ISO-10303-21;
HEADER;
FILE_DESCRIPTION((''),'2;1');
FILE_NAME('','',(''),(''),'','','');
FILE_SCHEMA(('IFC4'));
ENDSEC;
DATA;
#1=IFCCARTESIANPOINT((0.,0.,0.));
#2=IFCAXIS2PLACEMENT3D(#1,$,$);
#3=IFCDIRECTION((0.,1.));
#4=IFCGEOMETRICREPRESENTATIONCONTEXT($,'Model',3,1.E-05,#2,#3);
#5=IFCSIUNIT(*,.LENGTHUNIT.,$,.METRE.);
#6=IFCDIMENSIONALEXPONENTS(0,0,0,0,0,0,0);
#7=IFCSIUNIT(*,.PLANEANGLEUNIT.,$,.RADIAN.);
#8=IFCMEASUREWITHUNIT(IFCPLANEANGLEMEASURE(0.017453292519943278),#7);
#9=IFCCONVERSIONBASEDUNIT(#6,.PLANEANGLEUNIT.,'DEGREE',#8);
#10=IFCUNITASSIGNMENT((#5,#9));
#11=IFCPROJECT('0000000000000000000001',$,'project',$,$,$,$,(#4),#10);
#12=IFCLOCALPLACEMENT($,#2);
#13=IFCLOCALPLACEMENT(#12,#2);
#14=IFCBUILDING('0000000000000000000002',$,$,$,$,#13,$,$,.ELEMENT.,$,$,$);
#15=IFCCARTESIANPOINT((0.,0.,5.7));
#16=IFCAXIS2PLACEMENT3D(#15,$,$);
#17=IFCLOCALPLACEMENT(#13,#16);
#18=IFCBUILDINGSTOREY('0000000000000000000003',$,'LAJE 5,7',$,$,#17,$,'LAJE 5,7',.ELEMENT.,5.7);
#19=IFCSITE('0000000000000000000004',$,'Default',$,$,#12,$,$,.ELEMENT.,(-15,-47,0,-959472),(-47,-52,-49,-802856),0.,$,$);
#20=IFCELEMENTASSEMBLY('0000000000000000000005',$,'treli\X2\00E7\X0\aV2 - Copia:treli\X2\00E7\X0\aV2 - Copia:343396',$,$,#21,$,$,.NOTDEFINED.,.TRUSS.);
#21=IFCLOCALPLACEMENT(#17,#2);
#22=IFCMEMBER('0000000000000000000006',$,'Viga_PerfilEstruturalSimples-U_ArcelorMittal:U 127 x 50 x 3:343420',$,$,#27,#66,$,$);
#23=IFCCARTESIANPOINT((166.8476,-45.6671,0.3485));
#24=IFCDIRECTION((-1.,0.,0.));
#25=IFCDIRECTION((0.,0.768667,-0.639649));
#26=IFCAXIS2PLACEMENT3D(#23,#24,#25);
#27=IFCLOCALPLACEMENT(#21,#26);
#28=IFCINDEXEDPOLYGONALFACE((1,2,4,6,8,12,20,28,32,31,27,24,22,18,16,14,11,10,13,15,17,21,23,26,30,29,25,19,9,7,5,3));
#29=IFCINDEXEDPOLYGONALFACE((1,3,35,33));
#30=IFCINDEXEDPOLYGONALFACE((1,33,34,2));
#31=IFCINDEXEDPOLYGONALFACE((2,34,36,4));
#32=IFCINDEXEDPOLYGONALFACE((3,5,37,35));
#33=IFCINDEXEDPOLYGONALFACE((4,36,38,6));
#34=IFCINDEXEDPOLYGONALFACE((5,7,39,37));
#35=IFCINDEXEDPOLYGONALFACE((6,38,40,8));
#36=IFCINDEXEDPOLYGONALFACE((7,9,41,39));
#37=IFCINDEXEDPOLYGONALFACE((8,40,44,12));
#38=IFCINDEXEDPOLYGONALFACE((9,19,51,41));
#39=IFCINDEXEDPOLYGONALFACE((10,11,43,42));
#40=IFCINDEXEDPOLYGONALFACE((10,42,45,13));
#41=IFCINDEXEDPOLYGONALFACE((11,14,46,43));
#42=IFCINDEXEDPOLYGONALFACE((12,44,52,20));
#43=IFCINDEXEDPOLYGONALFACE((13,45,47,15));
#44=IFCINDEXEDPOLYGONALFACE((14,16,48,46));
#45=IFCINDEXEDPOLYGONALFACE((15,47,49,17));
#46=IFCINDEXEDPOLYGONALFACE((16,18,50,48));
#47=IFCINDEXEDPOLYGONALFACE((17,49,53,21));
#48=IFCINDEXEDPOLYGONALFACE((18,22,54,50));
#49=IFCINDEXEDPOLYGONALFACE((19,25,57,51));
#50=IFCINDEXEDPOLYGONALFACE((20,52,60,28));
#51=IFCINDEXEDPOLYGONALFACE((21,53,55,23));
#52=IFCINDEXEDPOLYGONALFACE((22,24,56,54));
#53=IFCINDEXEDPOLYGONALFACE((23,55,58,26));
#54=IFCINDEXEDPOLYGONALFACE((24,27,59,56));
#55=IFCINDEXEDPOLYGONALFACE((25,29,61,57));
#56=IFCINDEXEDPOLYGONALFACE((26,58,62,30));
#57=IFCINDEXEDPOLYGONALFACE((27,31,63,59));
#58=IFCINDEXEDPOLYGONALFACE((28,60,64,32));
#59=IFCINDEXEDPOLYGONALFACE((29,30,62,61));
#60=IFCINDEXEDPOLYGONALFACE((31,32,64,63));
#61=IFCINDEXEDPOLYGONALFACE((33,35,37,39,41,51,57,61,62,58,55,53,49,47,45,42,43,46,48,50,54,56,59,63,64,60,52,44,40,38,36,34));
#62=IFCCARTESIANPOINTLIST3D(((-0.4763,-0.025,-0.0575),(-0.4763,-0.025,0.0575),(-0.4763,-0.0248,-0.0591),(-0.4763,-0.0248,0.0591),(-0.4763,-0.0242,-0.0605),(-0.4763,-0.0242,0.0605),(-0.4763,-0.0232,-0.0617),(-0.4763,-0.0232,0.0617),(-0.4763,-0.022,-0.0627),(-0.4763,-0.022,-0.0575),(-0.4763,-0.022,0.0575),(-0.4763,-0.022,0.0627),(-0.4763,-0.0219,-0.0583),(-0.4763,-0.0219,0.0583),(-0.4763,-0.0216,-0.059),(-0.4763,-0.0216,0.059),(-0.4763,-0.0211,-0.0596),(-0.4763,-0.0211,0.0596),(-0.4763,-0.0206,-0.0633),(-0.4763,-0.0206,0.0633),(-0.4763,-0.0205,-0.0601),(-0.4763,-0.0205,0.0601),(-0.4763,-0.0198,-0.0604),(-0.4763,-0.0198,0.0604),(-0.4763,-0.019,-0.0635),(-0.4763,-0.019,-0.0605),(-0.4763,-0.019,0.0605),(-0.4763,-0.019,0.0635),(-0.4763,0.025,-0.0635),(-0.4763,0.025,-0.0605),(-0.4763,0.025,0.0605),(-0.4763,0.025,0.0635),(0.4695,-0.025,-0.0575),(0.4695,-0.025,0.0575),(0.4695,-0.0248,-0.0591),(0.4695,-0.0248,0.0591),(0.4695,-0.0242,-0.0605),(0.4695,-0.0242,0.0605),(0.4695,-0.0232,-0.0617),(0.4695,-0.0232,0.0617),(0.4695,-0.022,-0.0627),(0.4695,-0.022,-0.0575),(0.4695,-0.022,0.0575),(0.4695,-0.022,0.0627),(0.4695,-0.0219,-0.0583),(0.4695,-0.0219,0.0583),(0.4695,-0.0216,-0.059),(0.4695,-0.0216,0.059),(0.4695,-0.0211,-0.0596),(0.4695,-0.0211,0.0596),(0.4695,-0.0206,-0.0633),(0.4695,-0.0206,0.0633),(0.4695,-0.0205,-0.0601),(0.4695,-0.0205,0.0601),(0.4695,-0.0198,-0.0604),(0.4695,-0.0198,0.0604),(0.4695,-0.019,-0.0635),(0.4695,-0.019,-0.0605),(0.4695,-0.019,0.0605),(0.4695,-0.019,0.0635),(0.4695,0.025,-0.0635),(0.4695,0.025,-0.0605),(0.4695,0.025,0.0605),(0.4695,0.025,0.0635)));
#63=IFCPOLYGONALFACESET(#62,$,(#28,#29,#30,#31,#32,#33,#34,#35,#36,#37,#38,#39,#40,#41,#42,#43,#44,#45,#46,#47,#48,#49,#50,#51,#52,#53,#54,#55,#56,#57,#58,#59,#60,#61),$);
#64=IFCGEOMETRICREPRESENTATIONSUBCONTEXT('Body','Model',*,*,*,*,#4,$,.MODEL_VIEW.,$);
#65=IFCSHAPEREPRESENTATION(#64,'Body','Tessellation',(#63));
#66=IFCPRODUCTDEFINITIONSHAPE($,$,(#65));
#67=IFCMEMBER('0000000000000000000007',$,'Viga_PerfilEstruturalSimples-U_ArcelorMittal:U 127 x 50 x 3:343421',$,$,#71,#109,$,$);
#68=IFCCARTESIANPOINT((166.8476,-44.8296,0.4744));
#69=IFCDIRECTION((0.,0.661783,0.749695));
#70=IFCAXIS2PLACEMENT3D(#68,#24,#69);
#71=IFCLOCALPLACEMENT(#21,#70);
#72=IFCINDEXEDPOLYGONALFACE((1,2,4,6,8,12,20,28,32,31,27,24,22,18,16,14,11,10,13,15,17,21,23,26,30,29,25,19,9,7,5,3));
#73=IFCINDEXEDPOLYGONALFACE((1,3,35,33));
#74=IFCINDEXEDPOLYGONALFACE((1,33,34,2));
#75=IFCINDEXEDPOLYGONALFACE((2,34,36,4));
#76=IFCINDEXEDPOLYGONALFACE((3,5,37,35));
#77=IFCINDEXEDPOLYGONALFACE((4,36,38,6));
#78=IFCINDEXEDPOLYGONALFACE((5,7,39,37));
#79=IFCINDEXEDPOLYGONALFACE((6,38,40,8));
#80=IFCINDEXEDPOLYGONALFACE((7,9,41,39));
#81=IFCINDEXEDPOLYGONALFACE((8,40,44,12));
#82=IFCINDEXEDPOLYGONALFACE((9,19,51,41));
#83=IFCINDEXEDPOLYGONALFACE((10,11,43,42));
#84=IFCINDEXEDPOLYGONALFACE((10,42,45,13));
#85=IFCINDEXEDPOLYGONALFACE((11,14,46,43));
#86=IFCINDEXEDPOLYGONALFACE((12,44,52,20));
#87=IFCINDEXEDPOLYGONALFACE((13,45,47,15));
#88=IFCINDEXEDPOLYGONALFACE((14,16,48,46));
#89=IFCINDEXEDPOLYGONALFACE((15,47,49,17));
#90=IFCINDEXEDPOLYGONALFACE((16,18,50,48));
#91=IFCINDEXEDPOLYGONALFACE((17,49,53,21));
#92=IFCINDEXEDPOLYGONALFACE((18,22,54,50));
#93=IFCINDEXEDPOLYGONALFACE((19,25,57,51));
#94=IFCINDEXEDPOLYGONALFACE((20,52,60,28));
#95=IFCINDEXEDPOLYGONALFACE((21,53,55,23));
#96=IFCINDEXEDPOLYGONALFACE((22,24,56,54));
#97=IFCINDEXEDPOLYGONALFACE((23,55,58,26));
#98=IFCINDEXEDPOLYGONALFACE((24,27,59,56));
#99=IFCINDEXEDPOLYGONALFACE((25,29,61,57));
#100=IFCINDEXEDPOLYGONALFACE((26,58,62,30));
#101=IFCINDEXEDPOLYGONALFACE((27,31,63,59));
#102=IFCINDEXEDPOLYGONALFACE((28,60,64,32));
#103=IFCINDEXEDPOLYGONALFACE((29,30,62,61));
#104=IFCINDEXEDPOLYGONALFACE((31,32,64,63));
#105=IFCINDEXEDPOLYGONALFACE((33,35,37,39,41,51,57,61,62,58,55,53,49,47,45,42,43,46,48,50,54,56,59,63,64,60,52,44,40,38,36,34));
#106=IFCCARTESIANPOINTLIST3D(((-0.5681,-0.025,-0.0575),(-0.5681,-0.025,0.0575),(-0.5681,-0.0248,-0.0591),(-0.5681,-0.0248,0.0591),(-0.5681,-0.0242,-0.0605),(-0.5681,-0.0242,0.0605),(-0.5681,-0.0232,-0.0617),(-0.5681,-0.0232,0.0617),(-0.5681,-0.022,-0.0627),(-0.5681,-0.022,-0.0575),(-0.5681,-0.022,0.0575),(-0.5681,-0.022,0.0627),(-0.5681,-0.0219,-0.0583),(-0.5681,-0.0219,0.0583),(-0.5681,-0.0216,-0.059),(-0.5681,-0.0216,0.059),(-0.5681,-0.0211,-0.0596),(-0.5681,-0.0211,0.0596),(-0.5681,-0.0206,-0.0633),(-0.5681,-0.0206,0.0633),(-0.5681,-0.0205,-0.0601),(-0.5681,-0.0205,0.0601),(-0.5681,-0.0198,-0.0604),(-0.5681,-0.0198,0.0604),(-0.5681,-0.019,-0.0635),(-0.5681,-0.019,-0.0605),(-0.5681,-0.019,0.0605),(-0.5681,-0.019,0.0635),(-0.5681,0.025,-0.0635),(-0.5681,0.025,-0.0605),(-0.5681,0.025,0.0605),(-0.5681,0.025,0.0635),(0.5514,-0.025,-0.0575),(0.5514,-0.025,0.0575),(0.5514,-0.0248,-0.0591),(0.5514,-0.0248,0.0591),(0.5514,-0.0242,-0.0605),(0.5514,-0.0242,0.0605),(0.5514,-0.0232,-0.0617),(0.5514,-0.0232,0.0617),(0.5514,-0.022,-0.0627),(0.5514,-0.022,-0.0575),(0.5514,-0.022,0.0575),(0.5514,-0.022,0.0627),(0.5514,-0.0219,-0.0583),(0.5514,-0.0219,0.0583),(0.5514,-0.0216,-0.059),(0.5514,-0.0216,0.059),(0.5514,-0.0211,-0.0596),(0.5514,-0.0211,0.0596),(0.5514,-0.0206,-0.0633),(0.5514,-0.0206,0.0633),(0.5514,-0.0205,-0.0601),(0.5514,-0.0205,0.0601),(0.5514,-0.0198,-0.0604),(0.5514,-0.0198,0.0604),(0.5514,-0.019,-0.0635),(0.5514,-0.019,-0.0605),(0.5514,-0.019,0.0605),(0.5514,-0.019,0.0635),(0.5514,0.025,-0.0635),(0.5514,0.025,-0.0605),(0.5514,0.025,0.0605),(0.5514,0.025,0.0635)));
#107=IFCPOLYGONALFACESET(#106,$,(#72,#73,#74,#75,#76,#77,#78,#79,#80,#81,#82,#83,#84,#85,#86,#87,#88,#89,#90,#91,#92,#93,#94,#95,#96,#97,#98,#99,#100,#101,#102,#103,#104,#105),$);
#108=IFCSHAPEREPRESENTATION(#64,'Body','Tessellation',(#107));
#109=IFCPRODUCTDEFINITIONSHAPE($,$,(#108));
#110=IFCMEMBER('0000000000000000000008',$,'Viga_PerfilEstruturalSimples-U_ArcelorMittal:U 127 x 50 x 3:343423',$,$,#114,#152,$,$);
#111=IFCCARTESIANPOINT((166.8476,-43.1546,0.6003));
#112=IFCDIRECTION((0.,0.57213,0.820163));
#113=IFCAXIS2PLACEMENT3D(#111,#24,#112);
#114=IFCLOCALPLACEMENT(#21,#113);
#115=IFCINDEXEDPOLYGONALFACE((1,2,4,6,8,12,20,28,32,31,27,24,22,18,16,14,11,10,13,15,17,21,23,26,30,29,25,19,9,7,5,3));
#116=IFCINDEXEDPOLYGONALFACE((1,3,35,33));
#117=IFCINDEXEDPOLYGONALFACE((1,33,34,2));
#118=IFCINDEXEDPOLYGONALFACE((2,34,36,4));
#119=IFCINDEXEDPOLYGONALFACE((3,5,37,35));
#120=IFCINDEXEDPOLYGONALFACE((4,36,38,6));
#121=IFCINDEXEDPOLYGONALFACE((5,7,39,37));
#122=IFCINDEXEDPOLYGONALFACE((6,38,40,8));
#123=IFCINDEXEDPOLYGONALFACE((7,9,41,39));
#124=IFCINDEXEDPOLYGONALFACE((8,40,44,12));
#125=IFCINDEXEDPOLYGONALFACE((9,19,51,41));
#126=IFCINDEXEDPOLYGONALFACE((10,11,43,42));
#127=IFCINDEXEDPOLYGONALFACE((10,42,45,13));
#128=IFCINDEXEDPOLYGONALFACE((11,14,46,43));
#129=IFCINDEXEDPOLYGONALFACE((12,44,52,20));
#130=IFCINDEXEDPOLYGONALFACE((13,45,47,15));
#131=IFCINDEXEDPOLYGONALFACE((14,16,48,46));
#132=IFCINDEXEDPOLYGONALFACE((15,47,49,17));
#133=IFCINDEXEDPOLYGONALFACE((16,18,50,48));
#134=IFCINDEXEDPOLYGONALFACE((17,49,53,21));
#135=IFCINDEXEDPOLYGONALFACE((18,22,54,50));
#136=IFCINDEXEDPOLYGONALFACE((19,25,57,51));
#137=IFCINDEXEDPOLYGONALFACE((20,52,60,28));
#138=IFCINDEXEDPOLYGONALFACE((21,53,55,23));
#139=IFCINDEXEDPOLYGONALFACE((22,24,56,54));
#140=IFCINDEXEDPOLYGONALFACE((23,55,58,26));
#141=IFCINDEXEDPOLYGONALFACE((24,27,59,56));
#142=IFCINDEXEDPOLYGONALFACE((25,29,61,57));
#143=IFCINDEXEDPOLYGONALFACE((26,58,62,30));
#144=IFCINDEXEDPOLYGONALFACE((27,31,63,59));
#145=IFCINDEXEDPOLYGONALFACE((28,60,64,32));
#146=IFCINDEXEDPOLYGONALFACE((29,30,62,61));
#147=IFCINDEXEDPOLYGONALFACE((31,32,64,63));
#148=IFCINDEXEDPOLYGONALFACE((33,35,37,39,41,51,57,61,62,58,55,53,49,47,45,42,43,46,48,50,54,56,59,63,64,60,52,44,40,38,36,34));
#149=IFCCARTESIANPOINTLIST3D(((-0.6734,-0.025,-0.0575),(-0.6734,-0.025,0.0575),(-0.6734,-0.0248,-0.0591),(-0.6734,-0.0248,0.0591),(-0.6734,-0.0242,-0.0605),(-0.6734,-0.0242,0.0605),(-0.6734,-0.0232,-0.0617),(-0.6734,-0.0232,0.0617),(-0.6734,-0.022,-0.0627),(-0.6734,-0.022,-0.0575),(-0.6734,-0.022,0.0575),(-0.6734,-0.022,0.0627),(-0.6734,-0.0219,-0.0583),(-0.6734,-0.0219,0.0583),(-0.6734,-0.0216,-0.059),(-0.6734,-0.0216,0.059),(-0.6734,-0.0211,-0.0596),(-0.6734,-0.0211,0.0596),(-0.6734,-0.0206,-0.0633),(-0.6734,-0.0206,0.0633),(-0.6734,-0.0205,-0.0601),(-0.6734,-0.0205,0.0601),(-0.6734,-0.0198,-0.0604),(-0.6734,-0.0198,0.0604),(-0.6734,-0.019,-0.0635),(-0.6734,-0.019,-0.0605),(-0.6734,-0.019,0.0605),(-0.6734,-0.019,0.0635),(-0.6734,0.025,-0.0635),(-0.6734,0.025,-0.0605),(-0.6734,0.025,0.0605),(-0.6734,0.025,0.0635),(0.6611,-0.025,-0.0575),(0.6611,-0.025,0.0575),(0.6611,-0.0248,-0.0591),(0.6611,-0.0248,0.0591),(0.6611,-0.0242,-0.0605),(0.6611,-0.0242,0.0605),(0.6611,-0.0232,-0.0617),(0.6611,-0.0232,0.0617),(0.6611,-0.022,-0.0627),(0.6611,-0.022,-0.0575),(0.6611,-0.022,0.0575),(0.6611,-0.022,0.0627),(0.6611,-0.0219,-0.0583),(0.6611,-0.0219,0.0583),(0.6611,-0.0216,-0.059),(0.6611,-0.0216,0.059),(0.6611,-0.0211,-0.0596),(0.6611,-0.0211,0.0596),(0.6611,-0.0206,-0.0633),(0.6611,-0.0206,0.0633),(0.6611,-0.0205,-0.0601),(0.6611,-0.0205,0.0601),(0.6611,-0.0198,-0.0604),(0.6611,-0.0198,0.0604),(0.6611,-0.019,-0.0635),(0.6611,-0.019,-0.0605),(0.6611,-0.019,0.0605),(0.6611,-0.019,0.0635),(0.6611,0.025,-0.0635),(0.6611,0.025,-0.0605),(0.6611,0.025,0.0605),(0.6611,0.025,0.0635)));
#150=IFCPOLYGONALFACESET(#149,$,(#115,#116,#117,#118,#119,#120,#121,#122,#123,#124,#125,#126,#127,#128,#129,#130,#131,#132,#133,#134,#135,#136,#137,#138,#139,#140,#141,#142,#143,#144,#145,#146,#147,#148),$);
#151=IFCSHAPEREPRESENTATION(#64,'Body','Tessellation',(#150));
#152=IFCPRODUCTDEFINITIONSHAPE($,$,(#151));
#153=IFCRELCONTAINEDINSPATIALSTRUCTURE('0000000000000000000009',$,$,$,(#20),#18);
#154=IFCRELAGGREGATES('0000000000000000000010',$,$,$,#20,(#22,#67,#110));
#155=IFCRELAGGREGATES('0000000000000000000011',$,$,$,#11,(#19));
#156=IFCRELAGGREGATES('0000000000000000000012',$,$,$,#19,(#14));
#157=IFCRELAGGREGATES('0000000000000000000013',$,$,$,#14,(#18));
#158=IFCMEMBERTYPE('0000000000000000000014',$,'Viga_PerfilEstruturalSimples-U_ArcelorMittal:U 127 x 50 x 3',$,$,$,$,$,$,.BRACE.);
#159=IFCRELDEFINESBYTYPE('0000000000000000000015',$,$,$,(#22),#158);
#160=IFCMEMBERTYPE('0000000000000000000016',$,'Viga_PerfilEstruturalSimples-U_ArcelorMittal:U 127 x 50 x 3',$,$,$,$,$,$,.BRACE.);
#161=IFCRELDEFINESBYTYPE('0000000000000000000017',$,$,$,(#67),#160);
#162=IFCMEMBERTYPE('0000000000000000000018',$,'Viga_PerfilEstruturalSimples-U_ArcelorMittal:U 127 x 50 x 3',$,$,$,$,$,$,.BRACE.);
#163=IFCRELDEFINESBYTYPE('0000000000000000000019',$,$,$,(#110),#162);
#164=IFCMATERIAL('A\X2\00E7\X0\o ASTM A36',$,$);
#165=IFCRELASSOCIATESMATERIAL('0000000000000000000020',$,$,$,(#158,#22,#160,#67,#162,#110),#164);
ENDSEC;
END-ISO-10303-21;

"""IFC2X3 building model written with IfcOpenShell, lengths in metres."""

from ifc_helpers import new_model, entity, si_unit, converted_unit, direction, frame, frame_2d, origin, place, context, subcontext, project, spatial, polyline, circle_curve, parameter, trimmed, segment, composite_curve, outline, extrude, source, transform, mapped, material, type_object, type_shapes, element, aggregate, save


model = new_model("IFC2X3")

# Units and contexts
model_context = context("Model", 3, precision=1e-05, world=origin(), true_north=direction((0.0, 1.0)))
body_context = subcontext(model_context, "Body", "Model", "MODEL_VIEW")
ifc_project = project(units=[si_unit("LENGTHUNIT", "METRE"), converted_unit("PLANEANGLEUNIT", "DEGREE", entity("IfcPlaneAngleMeasure", 0.017453292519943278), si_unit("PLANEANGLEUNIT", "RADIAN"), dimensions=[0, 0, 0, 0, 0, 0, 0])], contexts=[model_context])

# Site, building, storey
site_placement = place(None, origin())
site = spatial("IfcSite", under=ifc_project, at=site_placement, Name="Default", CompositionType="ELEMENT", RefLatitude=(-15, -47, 0, -959472), RefLongitude=(-47, -52, -49, -802856), RefElevation=0.0)
building_placement = place(site_placement, origin())
building = spatial("IfcBuilding", under=site, at=building_placement, CompositionType="ELEMENT")
storey_placement = place(building_placement, frame((0.0, 0.0, 5.7)))
storey = spatial("IfcBuildingStorey", under=building, at=storey_placement, Name="LAJE 5,7", LongName="LAJE 5,7", CompositionType="ELEMENT", Elevation=5.7)

# Element assembly
assembly_1_placement = place(storey_placement, origin())
assembly_1 = element("IfcElementAssembly", 1, at=assembly_1_placement, inside=storey, Name="treliçaV2 - Copia:treliçaV2 - Copia:343396", AssemblyPlace="NOTDEFINED", PredefinedType="TRUSS")
ifc_material = material(Name="Aço ASTM A36")

# Members
member_type_1 = type_object("IfcMemberType", Name="Viga_PerfilEstruturalSimples-U_ArcelorMittal:U 127 x 50 x 3", PredefinedType="BRACE", material=ifc_material)
shared_shape_1 = source(origin(), body_context, "Body", "SweptSolid", [
    extrude(outline(composite_curve([segment(polyline([(-0.0575, -0.0192), (0.0575, -0.0192)]), True, "CONTINUOUS"), segment(trimmed(circle_curve(frame_2d((0.0575, -0.0132), x_axis=(0.0, 1.0)), 0.006), [parameter(180.0)], [parameter(270.0)], True, "PARAMETER"), True, "CONTINUOUS"), segment(polyline([(0.0635, -0.0132), (0.0635, 0.0308)]), True, "CONTINUOUS"), segment(polyline([(0.0635, 0.0308), (0.0605, 0.0308)]), True, "CONTINUOUS"), segment(polyline([(0.0605, 0.0308), (0.0605, -0.0132)]), True, "CONTINUOUS"), segment(trimmed(circle_curve(frame_2d((0.0575, -0.0132), x_axis=(0.0, 1.0)), 0.003), [parameter(180.0)], [parameter(270.0)], True, "PARAMETER"), False, "CONTINUOUS"), segment(polyline([(0.0575, -0.0162), (-0.0575, -0.0162)]), True, "CONTINUOUS"), segment(trimmed(circle_curve(frame_2d((-0.0575, -0.0132), x_axis=(0.0, 1.0)), 0.003), [parameter(90.0)], [parameter(180.0)], True, "PARAMETER"), False, "CONTINUOUS"), segment(polyline([(-0.0605, -0.0132), (-0.0605, 0.0308)]), True, "CONTINUOUS"), segment(polyline([(-0.0605, 0.0308), (-0.0635, 0.0308)]), True, "CONTINUOUS"), segment(polyline([(-0.0635, 0.0308), (-0.0635, -0.0132)]), True, "CONTINUOUS"), segment(trimmed(circle_curve(frame_2d((-0.0575, -0.0132), x_axis=(0.0, 1.0)), 0.006), [parameter(90.0)], [parameter(180.0)], True, "PARAMETER"), True, "CONTINUOUS")], self_intersect=False)), frame((-0.4763, -0.0058, 0.0), z_axis=(1.0, 0.0, 0.0), x_axis=(0.0, 0.0, -1.0)), (0.0, 0.0, 1.0), 0.9459),
])
type_shapes(member_type_1, [shared_shape_1])
member_1_placement = place(assembly_1_placement, frame((166.8476, -45.6671, 0.3485), z_axis=(-1.0, 0.0, 0.0), x_axis=(0.0, 0.768667, -0.639649)))
member_1 = element("IfcMember", 2, at=member_1_placement, type_object=member_type_1, material=ifc_material, Name="Viga_PerfilEstruturalSimples-U_ArcelorMittal:U 127 x 50 x 3:343420", context=body_context, shape_type="MappedRepresentation", body=[
    mapped(shared_shape_1, transform((0.0, 0.0, 0.0), scale=1.0)),
])
member_type_2 = type_object("IfcMemberType", Name="Viga_PerfilEstruturalSimples-U_ArcelorMittal:U 127 x 50 x 3", PredefinedType="BRACE", material=ifc_material)
shared_shape_2 = source(origin(), body_context, "Body", "SweptSolid", [
    extrude(outline(composite_curve([segment(polyline([(-0.0575, -0.0192), (0.0575, -0.0192)]), True, "CONTINUOUS"), segment(trimmed(circle_curve(frame_2d((0.0575, -0.0132), x_axis=(0.0, 1.0)), 0.006), [parameter(180.0)], [parameter(270.0)], True, "PARAMETER"), True, "CONTINUOUS"), segment(polyline([(0.0635, -0.0132), (0.0635, 0.0308)]), True, "CONTINUOUS"), segment(polyline([(0.0635, 0.0308), (0.0605, 0.0308)]), True, "CONTINUOUS"), segment(polyline([(0.0605, 0.0308), (0.0605, -0.0132)]), True, "CONTINUOUS"), segment(trimmed(circle_curve(frame_2d((0.0575, -0.0132), x_axis=(0.0, 1.0)), 0.003), [parameter(180.0)], [parameter(270.0)], True, "PARAMETER"), False, "CONTINUOUS"), segment(polyline([(0.0575, -0.0162), (-0.0575, -0.0162)]), True, "CONTINUOUS"), segment(trimmed(circle_curve(frame_2d((-0.0575, -0.0132), x_axis=(0.0, 1.0)), 0.003), [parameter(90.0)], [parameter(180.0)], True, "PARAMETER"), False, "CONTINUOUS"), segment(polyline([(-0.0605, -0.0132), (-0.0605, 0.0308)]), True, "CONTINUOUS"), segment(polyline([(-0.0605, 0.0308), (-0.0635, 0.0308)]), True, "CONTINUOUS"), segment(polyline([(-0.0635, 0.0308), (-0.0635, -0.0132)]), True, "CONTINUOUS"), segment(trimmed(circle_curve(frame_2d((-0.0575, -0.0132), x_axis=(0.0, 1.0)), 0.006), [parameter(90.0)], [parameter(180.0)], True, "PARAMETER"), True, "CONTINUOUS")], self_intersect=False)), frame((-0.5681, -0.0058, 0.0), z_axis=(1.0, 0.0, 0.0), x_axis=(0.0, 0.0, -1.0)), (0.0, 0.0, 1.0), 1.1195),
])
type_shapes(member_type_2, [shared_shape_2])
member_2_placement = place(assembly_1_placement, frame((166.8476, -44.8296, 0.4744), z_axis=(-1.0, 0.0, 0.0), x_axis=(0.0, 0.661783, 0.749695)))
member_2 = element("IfcMember", 3, at=member_2_placement, type_object=member_type_2, material=ifc_material, Name="Viga_PerfilEstruturalSimples-U_ArcelorMittal:U 127 x 50 x 3:343421", context=body_context, shape_type="MappedRepresentation", body=[
    mapped(shared_shape_2, transform((0.0, 0.0, 0.0), scale=1.0)),
])
member_type_3 = type_object("IfcMemberType", Name="Viga_PerfilEstruturalSimples-U_ArcelorMittal:U 127 x 50 x 3", PredefinedType="BRACE", material=ifc_material)
shared_shape_3 = source(origin(), body_context, "Body", "SweptSolid", [
    extrude(outline(composite_curve([segment(polyline([(-0.0575, -0.0192), (0.0575, -0.0192)]), True, "CONTINUOUS"), segment(trimmed(circle_curve(frame_2d((0.0575, -0.0132), x_axis=(0.0, 1.0)), 0.006), [parameter(180.0)], [parameter(270.0)], True, "PARAMETER"), True, "CONTINUOUS"), segment(polyline([(0.0635, -0.0132), (0.0635, 0.0308)]), True, "CONTINUOUS"), segment(polyline([(0.0635, 0.0308), (0.0605, 0.0308)]), True, "CONTINUOUS"), segment(polyline([(0.0605, 0.0308), (0.0605, -0.0132)]), True, "CONTINUOUS"), segment(trimmed(circle_curve(frame_2d((0.0575, -0.0132), x_axis=(0.0, 1.0)), 0.003), [parameter(180.0)], [parameter(270.0)], True, "PARAMETER"), False, "CONTINUOUS"), segment(polyline([(0.0575, -0.0162), (-0.0575, -0.0162)]), True, "CONTINUOUS"), segment(trimmed(circle_curve(frame_2d((-0.0575, -0.0132), x_axis=(0.0, 1.0)), 0.003), [parameter(90.0)], [parameter(180.0)], True, "PARAMETER"), False, "CONTINUOUS"), segment(polyline([(-0.0605, -0.0132), (-0.0605, 0.0308)]), True, "CONTINUOUS"), segment(polyline([(-0.0605, 0.0308), (-0.0635, 0.0308)]), True, "CONTINUOUS"), segment(polyline([(-0.0635, 0.0308), (-0.0635, -0.0132)]), True, "CONTINUOUS"), segment(trimmed(circle_curve(frame_2d((-0.0575, -0.0132), x_axis=(0.0, 1.0)), 0.006), [parameter(90.0)], [parameter(180.0)], True, "PARAMETER"), True, "CONTINUOUS")], self_intersect=False)), frame((-0.6734, -0.0058, 0.0), z_axis=(1.0, 0.0, 0.0), x_axis=(0.0, 0.0, -1.0)), (0.0, 0.0, 1.0), 1.3345),
])
type_shapes(member_type_3, [shared_shape_3])
member_3_placement = place(assembly_1_placement, frame((166.8476, -43.1546, 0.6003), z_axis=(-1.0, 0.0, 0.0), x_axis=(0.0, 0.57213, 0.820163)))
member_3 = element("IfcMember", 4, at=member_3_placement, type_object=member_type_3, material=ifc_material, Name="Viga_PerfilEstruturalSimples-U_ArcelorMittal:U 127 x 50 x 3:343423", context=body_context, shape_type="MappedRepresentation", body=[
    mapped(shared_shape_3, transform((0.0, 0.0, 0.0), scale=1.0)),
])
aggregate(assembly_1, [member_1, member_2, member_3])

save(model, "model.ifc")
